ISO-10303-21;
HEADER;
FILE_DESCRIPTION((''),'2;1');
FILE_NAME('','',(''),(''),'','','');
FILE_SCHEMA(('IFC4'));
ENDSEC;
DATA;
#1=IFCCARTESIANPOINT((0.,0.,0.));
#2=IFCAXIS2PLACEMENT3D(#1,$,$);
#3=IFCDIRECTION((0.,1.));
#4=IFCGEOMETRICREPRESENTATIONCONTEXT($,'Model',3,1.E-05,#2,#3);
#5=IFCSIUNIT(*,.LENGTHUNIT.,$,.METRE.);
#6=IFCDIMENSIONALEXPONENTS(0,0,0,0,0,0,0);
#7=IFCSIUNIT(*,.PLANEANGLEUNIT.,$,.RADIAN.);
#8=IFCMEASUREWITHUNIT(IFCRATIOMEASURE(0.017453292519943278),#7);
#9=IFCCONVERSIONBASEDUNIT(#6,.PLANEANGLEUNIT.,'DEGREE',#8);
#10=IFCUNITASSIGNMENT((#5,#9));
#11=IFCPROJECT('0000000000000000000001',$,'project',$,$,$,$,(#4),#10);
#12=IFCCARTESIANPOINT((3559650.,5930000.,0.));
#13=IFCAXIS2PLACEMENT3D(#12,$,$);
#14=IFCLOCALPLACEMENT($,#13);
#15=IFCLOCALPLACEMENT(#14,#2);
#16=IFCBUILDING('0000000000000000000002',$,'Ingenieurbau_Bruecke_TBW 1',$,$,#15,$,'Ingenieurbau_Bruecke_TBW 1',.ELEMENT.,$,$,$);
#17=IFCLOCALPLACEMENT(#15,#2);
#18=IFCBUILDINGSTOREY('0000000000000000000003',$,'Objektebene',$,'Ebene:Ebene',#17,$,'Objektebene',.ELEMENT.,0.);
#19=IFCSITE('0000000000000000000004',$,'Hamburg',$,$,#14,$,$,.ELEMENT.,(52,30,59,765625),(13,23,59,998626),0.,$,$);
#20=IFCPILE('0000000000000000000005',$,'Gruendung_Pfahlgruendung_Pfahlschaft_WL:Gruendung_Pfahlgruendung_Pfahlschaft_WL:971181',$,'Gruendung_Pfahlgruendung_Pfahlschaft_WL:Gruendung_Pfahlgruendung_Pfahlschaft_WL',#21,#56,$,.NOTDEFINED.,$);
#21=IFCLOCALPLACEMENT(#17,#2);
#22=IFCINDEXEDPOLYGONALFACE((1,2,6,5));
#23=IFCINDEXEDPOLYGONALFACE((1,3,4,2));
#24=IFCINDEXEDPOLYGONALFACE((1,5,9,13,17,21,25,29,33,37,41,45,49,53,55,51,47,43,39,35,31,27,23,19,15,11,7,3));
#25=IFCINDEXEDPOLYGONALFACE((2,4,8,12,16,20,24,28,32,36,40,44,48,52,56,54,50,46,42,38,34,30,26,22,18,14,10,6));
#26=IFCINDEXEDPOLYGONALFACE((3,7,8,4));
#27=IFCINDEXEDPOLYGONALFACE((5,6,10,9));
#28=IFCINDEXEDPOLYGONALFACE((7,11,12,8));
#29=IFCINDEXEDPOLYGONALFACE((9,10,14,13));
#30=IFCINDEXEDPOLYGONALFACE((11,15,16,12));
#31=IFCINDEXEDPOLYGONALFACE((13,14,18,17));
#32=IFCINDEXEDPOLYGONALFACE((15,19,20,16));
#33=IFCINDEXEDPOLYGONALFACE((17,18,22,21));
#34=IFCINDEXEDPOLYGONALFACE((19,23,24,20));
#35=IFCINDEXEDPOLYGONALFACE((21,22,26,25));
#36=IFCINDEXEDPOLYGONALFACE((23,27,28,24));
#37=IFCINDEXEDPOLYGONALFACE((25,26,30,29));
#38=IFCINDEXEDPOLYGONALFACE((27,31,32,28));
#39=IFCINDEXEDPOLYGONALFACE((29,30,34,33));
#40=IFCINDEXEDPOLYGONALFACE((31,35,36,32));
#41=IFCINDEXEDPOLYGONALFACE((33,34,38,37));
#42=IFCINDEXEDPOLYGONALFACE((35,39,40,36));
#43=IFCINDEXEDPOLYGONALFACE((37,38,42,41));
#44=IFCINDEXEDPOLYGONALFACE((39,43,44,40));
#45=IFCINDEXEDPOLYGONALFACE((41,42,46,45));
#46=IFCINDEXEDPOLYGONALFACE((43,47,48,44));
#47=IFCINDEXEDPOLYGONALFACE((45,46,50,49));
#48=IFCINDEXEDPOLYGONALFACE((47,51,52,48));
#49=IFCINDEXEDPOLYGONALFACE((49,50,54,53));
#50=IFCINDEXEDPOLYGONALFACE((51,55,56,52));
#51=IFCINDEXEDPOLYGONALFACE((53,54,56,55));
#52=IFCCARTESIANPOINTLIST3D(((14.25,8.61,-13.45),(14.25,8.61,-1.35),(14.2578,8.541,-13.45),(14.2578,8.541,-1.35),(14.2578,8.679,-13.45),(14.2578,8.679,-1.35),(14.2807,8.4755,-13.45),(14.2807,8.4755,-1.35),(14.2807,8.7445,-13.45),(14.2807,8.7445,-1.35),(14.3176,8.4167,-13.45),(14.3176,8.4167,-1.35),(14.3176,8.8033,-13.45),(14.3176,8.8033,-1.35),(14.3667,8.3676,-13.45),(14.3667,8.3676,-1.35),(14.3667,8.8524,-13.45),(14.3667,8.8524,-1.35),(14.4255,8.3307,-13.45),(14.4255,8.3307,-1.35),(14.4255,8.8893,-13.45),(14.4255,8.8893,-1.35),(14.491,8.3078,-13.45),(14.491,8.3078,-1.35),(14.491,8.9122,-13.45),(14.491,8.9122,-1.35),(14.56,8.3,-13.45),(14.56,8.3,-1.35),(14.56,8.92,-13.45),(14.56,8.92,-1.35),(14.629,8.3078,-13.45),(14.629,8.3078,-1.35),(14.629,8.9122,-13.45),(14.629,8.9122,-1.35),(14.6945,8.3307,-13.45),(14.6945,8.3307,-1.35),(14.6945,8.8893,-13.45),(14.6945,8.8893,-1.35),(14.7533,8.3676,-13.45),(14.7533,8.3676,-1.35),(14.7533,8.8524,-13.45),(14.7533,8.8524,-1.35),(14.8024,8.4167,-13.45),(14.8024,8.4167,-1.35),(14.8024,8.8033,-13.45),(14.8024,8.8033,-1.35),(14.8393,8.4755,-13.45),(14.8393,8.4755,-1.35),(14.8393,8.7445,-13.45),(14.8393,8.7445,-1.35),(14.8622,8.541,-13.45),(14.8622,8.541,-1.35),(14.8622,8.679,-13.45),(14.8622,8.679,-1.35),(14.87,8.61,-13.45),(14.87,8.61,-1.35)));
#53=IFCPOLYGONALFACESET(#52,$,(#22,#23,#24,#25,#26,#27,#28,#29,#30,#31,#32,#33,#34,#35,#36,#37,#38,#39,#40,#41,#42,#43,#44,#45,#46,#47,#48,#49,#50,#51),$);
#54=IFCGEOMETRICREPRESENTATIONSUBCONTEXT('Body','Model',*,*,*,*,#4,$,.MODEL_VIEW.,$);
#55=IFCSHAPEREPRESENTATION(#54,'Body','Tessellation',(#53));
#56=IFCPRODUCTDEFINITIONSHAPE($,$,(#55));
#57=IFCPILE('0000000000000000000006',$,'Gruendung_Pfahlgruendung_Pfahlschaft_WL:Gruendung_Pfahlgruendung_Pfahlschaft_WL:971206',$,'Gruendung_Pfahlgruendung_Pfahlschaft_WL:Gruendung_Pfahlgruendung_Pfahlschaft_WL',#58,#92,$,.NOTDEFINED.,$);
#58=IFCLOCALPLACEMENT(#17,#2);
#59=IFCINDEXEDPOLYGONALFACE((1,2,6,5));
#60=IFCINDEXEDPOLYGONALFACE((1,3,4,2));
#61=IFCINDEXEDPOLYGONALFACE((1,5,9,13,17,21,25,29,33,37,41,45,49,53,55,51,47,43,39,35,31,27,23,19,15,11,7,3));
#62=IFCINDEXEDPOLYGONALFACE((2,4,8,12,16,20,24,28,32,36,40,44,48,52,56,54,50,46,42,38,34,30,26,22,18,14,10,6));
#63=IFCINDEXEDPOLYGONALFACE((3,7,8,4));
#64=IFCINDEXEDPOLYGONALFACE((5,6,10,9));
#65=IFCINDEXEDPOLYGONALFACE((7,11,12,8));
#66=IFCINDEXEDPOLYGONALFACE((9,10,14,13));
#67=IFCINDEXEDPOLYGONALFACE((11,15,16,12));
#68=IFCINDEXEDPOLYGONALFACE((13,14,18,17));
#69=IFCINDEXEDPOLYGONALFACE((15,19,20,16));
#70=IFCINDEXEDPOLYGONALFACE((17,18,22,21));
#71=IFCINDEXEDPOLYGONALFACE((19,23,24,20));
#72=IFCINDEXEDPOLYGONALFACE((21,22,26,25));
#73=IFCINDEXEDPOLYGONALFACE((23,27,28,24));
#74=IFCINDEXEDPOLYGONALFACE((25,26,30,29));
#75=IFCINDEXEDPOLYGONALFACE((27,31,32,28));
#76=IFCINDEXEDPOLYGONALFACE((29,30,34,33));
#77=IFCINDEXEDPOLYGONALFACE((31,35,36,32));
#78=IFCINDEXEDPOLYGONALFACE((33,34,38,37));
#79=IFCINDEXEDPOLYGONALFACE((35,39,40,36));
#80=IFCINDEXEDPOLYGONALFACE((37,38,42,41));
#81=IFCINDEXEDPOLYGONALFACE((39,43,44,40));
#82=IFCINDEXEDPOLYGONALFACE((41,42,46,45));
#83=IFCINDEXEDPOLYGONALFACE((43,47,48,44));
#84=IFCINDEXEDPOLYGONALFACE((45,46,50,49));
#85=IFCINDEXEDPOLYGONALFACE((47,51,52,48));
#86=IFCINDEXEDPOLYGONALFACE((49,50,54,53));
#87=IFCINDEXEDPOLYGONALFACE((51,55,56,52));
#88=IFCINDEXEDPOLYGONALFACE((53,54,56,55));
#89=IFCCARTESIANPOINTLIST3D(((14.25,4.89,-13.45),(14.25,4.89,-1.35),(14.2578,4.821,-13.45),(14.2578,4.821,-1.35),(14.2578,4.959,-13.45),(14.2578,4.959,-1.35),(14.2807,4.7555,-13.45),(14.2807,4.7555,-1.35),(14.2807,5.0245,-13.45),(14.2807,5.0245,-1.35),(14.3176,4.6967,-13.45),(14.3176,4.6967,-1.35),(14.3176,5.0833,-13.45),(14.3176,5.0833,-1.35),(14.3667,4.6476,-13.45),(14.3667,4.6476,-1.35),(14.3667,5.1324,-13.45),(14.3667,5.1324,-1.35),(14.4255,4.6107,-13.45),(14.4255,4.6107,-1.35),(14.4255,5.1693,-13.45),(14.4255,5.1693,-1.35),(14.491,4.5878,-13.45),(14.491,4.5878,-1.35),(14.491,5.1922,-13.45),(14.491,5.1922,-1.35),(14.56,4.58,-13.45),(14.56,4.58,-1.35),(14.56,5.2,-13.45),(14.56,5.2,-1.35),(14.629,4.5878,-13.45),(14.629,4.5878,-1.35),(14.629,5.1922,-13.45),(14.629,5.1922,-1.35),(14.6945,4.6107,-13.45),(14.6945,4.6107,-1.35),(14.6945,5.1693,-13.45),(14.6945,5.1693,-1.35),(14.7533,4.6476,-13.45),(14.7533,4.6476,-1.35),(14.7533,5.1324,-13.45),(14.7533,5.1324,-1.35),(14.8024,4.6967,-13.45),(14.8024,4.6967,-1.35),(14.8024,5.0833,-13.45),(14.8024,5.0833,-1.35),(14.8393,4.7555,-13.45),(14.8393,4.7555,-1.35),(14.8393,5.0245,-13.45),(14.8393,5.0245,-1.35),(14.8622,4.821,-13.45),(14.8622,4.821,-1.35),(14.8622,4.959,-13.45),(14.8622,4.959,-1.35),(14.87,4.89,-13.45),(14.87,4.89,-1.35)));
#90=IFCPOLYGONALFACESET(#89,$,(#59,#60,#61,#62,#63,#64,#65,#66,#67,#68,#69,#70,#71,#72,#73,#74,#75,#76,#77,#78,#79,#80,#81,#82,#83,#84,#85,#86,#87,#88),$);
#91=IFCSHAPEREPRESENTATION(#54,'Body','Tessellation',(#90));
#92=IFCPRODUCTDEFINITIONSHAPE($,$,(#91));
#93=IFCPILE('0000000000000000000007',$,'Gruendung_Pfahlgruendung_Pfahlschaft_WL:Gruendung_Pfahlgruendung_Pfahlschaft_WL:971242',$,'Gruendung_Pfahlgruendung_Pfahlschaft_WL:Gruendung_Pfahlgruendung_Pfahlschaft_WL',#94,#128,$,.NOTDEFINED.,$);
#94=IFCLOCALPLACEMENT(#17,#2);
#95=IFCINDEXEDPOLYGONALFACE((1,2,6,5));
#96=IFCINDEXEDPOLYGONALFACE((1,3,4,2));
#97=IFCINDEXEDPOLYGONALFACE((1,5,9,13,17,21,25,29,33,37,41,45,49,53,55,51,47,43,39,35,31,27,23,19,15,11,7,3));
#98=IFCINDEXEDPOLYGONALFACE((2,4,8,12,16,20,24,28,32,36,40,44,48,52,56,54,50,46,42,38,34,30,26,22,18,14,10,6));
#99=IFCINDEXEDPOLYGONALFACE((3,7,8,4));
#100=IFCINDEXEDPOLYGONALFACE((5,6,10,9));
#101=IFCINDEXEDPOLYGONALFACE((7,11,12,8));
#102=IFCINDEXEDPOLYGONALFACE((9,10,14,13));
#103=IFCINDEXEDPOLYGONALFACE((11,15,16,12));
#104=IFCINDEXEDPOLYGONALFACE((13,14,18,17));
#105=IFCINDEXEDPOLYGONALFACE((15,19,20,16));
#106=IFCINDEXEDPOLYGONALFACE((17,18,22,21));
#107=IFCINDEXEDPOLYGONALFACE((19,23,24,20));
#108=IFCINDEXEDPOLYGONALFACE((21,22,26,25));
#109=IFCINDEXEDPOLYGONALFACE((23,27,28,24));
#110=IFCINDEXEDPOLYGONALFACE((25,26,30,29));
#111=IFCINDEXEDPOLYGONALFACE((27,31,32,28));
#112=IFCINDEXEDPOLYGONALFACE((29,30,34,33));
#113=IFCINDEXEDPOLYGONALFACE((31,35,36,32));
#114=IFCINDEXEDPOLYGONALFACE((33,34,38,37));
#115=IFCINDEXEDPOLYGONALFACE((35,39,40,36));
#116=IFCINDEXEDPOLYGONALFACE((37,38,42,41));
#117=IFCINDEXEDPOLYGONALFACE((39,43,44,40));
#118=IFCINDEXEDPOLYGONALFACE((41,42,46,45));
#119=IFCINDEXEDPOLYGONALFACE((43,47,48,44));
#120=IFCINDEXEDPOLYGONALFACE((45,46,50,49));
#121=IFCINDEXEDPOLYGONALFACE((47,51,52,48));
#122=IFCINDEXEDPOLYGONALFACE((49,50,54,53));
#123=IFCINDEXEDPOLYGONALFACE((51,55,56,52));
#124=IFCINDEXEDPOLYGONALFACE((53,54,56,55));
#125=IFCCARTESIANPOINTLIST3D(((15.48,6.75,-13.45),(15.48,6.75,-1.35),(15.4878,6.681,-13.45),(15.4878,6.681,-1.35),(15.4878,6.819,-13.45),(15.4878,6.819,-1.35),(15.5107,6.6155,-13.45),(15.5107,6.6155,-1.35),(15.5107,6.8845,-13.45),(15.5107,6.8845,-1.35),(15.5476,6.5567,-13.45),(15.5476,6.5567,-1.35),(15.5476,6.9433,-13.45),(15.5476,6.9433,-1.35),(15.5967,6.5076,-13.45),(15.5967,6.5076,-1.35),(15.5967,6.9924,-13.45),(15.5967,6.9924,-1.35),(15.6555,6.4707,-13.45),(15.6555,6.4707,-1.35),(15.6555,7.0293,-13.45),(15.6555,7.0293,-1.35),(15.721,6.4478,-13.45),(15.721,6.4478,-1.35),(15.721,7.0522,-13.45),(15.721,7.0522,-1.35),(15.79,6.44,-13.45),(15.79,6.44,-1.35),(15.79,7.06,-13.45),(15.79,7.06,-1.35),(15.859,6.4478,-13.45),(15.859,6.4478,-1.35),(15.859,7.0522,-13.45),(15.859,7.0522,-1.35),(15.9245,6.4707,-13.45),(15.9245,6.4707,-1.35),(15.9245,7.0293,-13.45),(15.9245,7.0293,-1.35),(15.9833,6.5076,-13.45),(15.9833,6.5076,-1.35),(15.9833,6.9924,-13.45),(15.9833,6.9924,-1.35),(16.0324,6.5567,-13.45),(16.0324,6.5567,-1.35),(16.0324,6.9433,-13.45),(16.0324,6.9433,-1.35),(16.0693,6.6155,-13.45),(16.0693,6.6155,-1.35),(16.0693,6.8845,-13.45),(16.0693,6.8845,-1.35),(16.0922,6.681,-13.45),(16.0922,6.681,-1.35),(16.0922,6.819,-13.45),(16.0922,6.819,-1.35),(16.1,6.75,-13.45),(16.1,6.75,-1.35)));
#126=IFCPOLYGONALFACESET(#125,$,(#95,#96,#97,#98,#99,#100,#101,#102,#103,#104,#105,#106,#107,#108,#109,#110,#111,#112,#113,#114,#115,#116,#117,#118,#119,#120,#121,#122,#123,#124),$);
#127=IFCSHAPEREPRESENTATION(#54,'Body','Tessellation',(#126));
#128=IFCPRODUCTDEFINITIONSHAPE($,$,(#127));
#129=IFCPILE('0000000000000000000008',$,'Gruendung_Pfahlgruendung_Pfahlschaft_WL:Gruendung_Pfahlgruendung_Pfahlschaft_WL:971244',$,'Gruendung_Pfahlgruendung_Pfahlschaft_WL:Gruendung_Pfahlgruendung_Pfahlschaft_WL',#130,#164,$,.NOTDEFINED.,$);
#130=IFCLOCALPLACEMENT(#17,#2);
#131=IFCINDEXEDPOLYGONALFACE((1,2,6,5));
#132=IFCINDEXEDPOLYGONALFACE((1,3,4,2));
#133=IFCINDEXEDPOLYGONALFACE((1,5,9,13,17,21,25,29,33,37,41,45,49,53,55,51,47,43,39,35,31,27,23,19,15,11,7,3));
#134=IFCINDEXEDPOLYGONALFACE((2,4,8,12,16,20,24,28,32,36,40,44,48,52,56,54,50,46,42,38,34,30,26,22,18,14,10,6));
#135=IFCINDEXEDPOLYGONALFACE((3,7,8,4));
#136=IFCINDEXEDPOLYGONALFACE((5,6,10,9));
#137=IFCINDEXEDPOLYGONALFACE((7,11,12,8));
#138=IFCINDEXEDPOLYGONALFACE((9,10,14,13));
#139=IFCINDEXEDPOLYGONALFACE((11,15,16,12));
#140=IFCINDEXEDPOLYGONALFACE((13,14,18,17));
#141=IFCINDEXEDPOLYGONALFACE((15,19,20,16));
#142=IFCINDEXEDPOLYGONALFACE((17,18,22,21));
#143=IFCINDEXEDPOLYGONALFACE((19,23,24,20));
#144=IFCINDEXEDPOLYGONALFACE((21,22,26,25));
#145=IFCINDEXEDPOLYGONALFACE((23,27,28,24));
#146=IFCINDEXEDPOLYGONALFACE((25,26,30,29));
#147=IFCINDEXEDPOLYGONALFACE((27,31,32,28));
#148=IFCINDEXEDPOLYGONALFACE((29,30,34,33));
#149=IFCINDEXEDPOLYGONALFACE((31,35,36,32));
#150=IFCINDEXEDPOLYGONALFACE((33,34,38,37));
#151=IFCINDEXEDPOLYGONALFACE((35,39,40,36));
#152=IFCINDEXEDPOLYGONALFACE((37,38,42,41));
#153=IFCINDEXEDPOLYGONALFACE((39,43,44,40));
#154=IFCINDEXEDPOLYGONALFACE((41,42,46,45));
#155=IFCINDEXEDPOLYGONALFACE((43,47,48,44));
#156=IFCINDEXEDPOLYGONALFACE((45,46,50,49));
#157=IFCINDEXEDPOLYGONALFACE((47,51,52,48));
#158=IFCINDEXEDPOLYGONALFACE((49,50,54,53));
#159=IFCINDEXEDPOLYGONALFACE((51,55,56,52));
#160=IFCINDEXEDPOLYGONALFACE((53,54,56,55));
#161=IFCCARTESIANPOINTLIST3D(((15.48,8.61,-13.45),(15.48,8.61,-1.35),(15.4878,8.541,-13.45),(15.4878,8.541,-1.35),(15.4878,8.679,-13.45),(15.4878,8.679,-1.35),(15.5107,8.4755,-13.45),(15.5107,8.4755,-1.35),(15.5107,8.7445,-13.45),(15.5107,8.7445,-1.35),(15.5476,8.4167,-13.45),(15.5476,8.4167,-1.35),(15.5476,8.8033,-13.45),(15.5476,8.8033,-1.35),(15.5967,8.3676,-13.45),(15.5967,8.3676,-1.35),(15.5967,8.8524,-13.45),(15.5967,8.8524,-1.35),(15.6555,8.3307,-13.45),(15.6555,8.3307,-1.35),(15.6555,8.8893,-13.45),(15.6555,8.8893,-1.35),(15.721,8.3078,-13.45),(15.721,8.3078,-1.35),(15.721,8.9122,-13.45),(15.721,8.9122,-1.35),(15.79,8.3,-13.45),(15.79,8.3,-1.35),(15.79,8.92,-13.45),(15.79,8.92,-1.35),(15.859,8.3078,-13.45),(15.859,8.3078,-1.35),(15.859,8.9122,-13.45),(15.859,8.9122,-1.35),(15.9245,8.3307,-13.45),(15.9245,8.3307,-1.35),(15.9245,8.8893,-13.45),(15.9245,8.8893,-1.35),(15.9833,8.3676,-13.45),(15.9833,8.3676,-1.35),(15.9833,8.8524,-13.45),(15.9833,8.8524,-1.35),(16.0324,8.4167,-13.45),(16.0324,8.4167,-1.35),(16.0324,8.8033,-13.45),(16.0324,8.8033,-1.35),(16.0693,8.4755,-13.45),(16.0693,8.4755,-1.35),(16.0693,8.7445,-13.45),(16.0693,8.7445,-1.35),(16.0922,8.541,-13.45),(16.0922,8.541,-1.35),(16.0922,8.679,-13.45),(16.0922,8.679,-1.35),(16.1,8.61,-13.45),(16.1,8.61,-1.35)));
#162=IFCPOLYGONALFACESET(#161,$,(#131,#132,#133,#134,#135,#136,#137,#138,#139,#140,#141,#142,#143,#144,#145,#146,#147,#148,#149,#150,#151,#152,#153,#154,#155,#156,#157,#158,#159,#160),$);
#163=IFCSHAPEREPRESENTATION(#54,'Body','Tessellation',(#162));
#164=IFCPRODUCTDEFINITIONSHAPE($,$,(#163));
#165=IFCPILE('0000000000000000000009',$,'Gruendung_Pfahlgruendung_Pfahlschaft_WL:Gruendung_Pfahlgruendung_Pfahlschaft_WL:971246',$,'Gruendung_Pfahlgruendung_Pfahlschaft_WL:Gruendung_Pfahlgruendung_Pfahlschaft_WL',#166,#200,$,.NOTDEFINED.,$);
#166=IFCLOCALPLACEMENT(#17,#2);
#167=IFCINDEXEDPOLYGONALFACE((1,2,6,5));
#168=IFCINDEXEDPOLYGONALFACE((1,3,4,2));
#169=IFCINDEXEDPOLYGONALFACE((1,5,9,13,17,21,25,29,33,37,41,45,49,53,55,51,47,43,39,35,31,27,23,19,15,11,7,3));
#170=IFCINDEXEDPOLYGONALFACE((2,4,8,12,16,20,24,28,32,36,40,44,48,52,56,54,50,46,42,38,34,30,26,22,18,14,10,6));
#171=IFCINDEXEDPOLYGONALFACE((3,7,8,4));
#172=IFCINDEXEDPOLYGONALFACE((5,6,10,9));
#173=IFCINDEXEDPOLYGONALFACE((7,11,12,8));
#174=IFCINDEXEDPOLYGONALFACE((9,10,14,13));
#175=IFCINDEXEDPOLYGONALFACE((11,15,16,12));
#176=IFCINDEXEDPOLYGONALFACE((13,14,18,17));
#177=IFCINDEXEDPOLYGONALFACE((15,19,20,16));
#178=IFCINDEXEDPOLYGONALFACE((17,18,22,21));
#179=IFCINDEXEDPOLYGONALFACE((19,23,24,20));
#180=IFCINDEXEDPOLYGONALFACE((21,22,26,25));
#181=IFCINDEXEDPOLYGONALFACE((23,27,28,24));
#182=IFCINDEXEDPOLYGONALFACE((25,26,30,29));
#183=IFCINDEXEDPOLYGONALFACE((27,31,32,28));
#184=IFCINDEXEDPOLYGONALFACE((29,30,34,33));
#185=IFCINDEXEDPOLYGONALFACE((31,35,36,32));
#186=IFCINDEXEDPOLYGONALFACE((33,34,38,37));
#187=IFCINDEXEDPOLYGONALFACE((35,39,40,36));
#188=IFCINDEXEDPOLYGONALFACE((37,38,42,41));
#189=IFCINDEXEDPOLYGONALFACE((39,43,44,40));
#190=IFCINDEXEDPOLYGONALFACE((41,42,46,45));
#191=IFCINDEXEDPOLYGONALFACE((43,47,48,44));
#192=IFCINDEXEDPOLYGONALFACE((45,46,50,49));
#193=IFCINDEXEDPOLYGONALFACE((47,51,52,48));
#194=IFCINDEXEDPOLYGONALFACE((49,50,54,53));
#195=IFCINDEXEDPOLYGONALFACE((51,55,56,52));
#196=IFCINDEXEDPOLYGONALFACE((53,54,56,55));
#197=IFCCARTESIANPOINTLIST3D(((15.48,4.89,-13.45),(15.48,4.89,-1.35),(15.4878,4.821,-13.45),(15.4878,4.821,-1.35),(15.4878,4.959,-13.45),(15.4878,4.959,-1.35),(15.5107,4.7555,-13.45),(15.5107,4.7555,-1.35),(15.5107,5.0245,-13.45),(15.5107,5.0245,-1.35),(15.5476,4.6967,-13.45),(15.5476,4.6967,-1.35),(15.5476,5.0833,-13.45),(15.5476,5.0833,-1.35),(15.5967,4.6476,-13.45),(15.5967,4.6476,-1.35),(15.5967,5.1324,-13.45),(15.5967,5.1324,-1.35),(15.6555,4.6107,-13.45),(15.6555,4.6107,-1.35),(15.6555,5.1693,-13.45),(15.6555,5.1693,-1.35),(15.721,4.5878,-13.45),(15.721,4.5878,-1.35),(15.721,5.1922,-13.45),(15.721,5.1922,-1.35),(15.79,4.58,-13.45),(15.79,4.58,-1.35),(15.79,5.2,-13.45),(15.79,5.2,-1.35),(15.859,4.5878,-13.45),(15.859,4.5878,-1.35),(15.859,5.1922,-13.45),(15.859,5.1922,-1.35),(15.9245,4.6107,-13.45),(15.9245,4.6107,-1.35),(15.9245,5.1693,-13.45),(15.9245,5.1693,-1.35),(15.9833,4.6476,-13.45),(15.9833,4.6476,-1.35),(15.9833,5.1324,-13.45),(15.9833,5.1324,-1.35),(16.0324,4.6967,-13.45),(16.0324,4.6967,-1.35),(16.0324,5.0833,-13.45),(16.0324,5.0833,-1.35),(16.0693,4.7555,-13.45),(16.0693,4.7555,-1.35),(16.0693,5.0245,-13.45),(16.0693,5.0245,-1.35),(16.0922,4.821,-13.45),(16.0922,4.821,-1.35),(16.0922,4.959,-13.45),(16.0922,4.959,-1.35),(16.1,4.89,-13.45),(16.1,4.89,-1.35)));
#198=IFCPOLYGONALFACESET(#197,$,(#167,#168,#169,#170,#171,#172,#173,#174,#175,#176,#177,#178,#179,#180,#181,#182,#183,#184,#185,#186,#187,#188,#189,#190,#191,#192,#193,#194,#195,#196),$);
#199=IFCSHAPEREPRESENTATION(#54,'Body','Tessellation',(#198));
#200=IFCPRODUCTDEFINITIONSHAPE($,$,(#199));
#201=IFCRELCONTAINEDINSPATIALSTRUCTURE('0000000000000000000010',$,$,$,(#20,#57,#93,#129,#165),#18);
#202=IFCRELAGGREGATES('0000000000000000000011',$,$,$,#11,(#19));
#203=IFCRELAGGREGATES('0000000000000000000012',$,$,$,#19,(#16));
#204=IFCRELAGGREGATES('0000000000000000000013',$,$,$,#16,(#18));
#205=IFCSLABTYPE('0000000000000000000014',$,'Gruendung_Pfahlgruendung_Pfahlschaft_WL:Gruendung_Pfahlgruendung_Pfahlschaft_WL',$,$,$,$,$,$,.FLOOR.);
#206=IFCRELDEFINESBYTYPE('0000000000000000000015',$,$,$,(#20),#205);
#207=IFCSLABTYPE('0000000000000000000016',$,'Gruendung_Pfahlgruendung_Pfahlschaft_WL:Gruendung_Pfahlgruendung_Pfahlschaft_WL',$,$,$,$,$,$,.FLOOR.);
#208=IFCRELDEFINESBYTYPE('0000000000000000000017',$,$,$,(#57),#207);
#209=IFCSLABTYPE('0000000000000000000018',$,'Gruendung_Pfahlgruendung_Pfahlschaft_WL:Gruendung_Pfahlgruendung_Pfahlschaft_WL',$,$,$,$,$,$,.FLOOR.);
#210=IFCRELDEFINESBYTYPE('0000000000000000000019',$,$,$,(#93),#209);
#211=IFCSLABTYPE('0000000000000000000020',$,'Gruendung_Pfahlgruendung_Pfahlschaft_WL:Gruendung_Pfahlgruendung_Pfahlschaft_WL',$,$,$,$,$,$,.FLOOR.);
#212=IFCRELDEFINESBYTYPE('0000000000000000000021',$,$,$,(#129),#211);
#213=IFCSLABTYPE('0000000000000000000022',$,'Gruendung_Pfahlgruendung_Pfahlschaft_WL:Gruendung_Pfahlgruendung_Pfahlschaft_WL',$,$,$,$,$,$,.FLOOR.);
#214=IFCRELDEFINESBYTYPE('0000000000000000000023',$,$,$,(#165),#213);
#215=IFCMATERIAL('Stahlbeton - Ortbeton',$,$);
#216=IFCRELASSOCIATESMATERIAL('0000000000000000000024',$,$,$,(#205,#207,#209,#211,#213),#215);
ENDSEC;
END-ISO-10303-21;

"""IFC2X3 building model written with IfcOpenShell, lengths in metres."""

from ifc_helpers import new_model, entity, si_unit, converted_unit, direction, frame, frame_2d, origin, origin_2d_with_axis, place, context, subcontext, project, spatial, circle, extrude, material, type_object, element, save


model = new_model("IFC2X3")

# Units and contexts
model_context = context("Model", 3, precision=1e-05, world=origin(), true_north=direction((0.0, 1.0)))
body_context = subcontext(model_context, "Body", "Model", "MODEL_VIEW")
ifc_project = project(units=[si_unit("LENGTHUNIT", "METRE"), converted_unit("PLANEANGLEUNIT", "DEGREE", entity("IfcRatioMeasure", 0.017453292519943278), si_unit("PLANEANGLEUNIT", "RADIAN"), dimensions=[0, 0, 0, 0, 0, 0, 0])], contexts=[model_context])

# Site, building, storey
site_placement = place(None, frame((3559650.0, 5930000.0, 0.0)))
site = spatial("IfcSite", under=ifc_project, at=site_placement, Name="Hamburg", CompositionType="ELEMENT", RefLatitude=(52, 30, 59, 765625), RefLongitude=(13, 23, 59, 998626), RefElevation=0.0)
building_placement = place(site_placement, origin())
building = spatial("IfcBuilding", under=site, at=building_placement, Name="Ingenieurbau_Bruecke_TBW 1", LongName="Ingenieurbau_Bruecke_TBW 1", CompositionType="ELEMENT")
storey_placement = place(building_placement, origin())
storey = spatial("IfcBuildingStorey", under=building, at=storey_placement, Name="Objektebene", ObjectType="Ebene:Ebene", LongName="Objektebene", CompositionType="ELEMENT", Elevation=0.0)

# Piles
ifc_material_1 = material(Name="Stahlbeton - Ortbeton")
slab_type_1 = type_object("IfcSlabType", Name="Gruendung_Pfahlgruendung_Pfahlschaft_WL:Gruendung_Pfahlgruendung_Pfahlschaft_WL", PredefinedType="FLOOR", material=ifc_material_1)
pile_1_placement = place(storey_placement, origin())
element("IfcPile", 1, at=pile_1_placement, inside=storey, type_object=slab_type_1, Name="Gruendung_Pfahlgruendung_Pfahlschaft_WL:Gruendung_Pfahlgruendung_Pfahlschaft_WL:971181", ObjectType="Gruendung_Pfahlgruendung_Pfahlschaft_WL:Gruendung_Pfahlgruendung_Pfahlschaft_WL", PredefinedType="NOTDEFINED", context=body_context, shape_type="SweptSolid", body=[
    extrude(circle(Radius=0.31, at=frame_2d((0.0, 0.0), x_axis=(1.0, 0.0))), frame((14.56, 8.61, -13.45)), (0.0, 0.0, 1.0), 12.1),
])
slab_type_2 = type_object("IfcSlabType", Name="Gruendung_Pfahlgruendung_Pfahlschaft_WL:Gruendung_Pfahlgruendung_Pfahlschaft_WL", PredefinedType="FLOOR", material=ifc_material_1)
pile_2_placement = place(storey_placement, origin())
element("IfcPile", 2, at=pile_2_placement, inside=storey, type_object=slab_type_2, Name="Gruendung_Pfahlgruendung_Pfahlschaft_WL:Gruendung_Pfahlgruendung_Pfahlschaft_WL:971206", ObjectType="Gruendung_Pfahlgruendung_Pfahlschaft_WL:Gruendung_Pfahlgruendung_Pfahlschaft_WL", PredefinedType="NOTDEFINED", context=body_context, shape_type="SweptSolid", body=[
    extrude(circle(Radius=0.31, at=origin_2d_with_axis()), frame((14.56, 4.89, -13.45)), (0.0, 0.0, 1.0), 12.1),
])
slab_type_3 = type_object("IfcSlabType", Name="Gruendung_Pfahlgruendung_Pfahlschaft_WL:Gruendung_Pfahlgruendung_Pfahlschaft_WL", PredefinedType="FLOOR", material=ifc_material_1)
pile_3_placement = place(storey_placement, origin())
element("IfcPile", 3, at=pile_3_placement, inside=storey, type_object=slab_type_3, Name="Gruendung_Pfahlgruendung_Pfahlschaft_WL:Gruendung_Pfahlgruendung_Pfahlschaft_WL:971242", ObjectType="Gruendung_Pfahlgruendung_Pfahlschaft_WL:Gruendung_Pfahlgruendung_Pfahlschaft_WL", PredefinedType="NOTDEFINED", context=body_context, shape_type="SweptSolid", body=[
    extrude(circle(Radius=0.31, at=frame_2d((0.0, 0.0), x_axis=(1.0, 0.0))), frame((15.79, 6.75, -13.45)), (0.0, 0.0, 1.0), 12.1),
])
slab_type_4 = type_object("IfcSlabType", Name="Gruendung_Pfahlgruendung_Pfahlschaft_WL:Gruendung_Pfahlgruendung_Pfahlschaft_WL", PredefinedType="FLOOR", material=ifc_material_1)
pile_4_placement = place(storey_placement, origin())
element("IfcPile", 4, at=pile_4_placement, inside=storey, type_object=slab_type_4, Name="Gruendung_Pfahlgruendung_Pfahlschaft_WL:Gruendung_Pfahlgruendung_Pfahlschaft_WL:971244", ObjectType="Gruendung_Pfahlgruendung_Pfahlschaft_WL:Gruendung_Pfahlgruendung_Pfahlschaft_WL", PredefinedType="NOTDEFINED", context=body_context, shape_type="SweptSolid", body=[
    extrude(circle(Radius=0.31, at=frame_2d((0.0, 0.0), x_axis=(1.0, 0.0))), frame((15.79, 8.61, -13.45)), (0.0, 0.0, 1.0), 12.1),
])
slab_type_5 = type_object("IfcSlabType", Name="Gruendung_Pfahlgruendung_Pfahlschaft_WL:Gruendung_Pfahlgruendung_Pfahlschaft_WL", PredefinedType="FLOOR", material=ifc_material_1)
pile_5_placement = place(storey_placement, origin())
element("IfcPile", 5, at=pile_5_placement, inside=storey, type_object=slab_type_5, Name="Gruendung_Pfahlgruendung_Pfahlschaft_WL:Gruendung_Pfahlgruendung_Pfahlschaft_WL:971246", ObjectType="Gruendung_Pfahlgruendung_Pfahlschaft_WL:Gruendung_Pfahlgruendung_Pfahlschaft_WL", PredefinedType="NOTDEFINED", context=body_context, shape_type="SweptSolid", body=[
    extrude(circle(Radius=0.31, at=origin_2d_with_axis()), frame((15.79, 4.89, -13.45)), (0.0, 0.0, 1.0), 12.1),
])

save(model, "model.ifc")
